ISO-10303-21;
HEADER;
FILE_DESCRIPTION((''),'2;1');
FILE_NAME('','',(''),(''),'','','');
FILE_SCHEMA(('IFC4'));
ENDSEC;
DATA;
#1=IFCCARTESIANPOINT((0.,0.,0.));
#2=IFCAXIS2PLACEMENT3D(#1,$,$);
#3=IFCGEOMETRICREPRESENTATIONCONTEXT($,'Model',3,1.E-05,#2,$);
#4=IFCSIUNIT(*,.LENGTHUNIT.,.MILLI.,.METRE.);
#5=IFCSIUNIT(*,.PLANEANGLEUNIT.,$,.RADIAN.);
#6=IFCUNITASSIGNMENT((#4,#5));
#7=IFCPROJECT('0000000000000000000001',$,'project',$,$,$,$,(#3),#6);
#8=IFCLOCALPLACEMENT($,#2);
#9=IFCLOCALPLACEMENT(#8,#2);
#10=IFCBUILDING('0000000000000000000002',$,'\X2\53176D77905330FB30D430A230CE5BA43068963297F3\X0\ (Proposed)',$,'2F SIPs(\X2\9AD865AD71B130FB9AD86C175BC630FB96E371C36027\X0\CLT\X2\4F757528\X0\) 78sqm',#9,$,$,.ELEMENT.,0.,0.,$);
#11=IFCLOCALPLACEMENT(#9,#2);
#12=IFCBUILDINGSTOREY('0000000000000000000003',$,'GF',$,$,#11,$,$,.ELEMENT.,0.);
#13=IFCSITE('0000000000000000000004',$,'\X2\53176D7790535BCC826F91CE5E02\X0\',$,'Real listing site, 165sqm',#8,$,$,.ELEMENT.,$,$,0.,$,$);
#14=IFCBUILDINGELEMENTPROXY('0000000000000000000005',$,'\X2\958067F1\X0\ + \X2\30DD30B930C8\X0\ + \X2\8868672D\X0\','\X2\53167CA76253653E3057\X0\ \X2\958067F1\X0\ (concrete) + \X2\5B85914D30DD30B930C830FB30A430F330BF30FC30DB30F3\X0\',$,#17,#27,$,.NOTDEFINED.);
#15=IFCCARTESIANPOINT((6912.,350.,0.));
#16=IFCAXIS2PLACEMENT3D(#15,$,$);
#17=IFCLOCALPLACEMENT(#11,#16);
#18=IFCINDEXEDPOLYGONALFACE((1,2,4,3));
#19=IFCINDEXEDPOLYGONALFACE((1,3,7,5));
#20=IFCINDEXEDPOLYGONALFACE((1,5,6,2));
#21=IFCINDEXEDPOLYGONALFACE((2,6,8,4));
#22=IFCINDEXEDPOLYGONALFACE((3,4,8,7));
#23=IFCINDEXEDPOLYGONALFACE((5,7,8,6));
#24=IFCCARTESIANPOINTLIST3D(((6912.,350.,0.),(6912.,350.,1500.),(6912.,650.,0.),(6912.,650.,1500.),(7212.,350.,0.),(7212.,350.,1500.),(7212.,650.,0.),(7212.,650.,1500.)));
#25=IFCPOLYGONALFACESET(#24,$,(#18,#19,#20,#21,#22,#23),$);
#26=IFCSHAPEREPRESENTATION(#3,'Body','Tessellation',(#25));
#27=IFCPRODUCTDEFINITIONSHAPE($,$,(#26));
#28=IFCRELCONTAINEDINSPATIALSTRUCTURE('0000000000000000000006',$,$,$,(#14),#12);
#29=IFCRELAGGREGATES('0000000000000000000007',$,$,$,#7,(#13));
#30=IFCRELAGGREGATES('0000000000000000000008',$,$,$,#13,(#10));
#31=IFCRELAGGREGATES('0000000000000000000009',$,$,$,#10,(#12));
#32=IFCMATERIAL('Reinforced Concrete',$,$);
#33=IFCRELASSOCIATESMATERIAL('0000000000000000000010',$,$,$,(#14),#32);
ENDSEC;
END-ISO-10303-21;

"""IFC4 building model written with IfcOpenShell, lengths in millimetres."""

from ifc_helpers import new_model, si_unit, frame, frame_2d, origin, place, context, project, spatial, rectangle, extrude, material, element, save


model = new_model("IFC4")

# Units and contexts
model_context = context("Model", 3, precision=1e-05, world=origin())
ifc_project = project(units=[si_unit("LENGTHUNIT", "METRE", prefix="MILLI"), si_unit("PLANEANGLEUNIT", "RADIAN")], contexts=[model_context])

# Site, building, storey
site_placement = place(None, origin())
site = spatial("IfcSite", under=ifc_project, at=site_placement, Name="北海道富良野市", ObjectType="Real listing site, 165sqm", CompositionType="ELEMENT", RefElevation=0.0)
building_placement = place(site_placement, origin())
building = spatial("IfcBuilding", under=site, at=building_placement, Name="北海道・ピアノ室と防音 (Proposed)", ObjectType="2F SIPs(高断熱・高気密・難燃性CLT併用) 78sqm", CompositionType="ELEMENT", ElevationOfRefHeight=0.0, ElevationOfTerrain=0.0)
storey_placement = place(building_placement, origin())
storey = spatial("IfcBuildingStorey", under=building, at=storey_placement, Name="GF", CompositionType="ELEMENT", Elevation=0.0)

# Shared definitions
ifc_material_1 = material(Name="Reinforced Concrete")

# Building element proxy
proxy_placement = place(storey_placement, frame((6912.0, 350.0, 0.0)))
element("IfcBuildingElementProxy", 1, at=proxy_placement, inside=storey, material=ifc_material_1, Name="門柱 + ポスト + 表札", Description="化粧打放し 門柱 (concrete) + 宅配ポスト・インターホン", PredefinedType="NOTDEFINED", context=model_context, shape_type="SweptSolid", body=[
    extrude(rectangle(XDim=300.0, YDim=300.0, at=frame_2d((150.0, 150.0))), frame((6912.0, 350.0, 0.0)), (0.0, 0.0, 1.0), 1500.0),
])

save(model, "model.ifc")
